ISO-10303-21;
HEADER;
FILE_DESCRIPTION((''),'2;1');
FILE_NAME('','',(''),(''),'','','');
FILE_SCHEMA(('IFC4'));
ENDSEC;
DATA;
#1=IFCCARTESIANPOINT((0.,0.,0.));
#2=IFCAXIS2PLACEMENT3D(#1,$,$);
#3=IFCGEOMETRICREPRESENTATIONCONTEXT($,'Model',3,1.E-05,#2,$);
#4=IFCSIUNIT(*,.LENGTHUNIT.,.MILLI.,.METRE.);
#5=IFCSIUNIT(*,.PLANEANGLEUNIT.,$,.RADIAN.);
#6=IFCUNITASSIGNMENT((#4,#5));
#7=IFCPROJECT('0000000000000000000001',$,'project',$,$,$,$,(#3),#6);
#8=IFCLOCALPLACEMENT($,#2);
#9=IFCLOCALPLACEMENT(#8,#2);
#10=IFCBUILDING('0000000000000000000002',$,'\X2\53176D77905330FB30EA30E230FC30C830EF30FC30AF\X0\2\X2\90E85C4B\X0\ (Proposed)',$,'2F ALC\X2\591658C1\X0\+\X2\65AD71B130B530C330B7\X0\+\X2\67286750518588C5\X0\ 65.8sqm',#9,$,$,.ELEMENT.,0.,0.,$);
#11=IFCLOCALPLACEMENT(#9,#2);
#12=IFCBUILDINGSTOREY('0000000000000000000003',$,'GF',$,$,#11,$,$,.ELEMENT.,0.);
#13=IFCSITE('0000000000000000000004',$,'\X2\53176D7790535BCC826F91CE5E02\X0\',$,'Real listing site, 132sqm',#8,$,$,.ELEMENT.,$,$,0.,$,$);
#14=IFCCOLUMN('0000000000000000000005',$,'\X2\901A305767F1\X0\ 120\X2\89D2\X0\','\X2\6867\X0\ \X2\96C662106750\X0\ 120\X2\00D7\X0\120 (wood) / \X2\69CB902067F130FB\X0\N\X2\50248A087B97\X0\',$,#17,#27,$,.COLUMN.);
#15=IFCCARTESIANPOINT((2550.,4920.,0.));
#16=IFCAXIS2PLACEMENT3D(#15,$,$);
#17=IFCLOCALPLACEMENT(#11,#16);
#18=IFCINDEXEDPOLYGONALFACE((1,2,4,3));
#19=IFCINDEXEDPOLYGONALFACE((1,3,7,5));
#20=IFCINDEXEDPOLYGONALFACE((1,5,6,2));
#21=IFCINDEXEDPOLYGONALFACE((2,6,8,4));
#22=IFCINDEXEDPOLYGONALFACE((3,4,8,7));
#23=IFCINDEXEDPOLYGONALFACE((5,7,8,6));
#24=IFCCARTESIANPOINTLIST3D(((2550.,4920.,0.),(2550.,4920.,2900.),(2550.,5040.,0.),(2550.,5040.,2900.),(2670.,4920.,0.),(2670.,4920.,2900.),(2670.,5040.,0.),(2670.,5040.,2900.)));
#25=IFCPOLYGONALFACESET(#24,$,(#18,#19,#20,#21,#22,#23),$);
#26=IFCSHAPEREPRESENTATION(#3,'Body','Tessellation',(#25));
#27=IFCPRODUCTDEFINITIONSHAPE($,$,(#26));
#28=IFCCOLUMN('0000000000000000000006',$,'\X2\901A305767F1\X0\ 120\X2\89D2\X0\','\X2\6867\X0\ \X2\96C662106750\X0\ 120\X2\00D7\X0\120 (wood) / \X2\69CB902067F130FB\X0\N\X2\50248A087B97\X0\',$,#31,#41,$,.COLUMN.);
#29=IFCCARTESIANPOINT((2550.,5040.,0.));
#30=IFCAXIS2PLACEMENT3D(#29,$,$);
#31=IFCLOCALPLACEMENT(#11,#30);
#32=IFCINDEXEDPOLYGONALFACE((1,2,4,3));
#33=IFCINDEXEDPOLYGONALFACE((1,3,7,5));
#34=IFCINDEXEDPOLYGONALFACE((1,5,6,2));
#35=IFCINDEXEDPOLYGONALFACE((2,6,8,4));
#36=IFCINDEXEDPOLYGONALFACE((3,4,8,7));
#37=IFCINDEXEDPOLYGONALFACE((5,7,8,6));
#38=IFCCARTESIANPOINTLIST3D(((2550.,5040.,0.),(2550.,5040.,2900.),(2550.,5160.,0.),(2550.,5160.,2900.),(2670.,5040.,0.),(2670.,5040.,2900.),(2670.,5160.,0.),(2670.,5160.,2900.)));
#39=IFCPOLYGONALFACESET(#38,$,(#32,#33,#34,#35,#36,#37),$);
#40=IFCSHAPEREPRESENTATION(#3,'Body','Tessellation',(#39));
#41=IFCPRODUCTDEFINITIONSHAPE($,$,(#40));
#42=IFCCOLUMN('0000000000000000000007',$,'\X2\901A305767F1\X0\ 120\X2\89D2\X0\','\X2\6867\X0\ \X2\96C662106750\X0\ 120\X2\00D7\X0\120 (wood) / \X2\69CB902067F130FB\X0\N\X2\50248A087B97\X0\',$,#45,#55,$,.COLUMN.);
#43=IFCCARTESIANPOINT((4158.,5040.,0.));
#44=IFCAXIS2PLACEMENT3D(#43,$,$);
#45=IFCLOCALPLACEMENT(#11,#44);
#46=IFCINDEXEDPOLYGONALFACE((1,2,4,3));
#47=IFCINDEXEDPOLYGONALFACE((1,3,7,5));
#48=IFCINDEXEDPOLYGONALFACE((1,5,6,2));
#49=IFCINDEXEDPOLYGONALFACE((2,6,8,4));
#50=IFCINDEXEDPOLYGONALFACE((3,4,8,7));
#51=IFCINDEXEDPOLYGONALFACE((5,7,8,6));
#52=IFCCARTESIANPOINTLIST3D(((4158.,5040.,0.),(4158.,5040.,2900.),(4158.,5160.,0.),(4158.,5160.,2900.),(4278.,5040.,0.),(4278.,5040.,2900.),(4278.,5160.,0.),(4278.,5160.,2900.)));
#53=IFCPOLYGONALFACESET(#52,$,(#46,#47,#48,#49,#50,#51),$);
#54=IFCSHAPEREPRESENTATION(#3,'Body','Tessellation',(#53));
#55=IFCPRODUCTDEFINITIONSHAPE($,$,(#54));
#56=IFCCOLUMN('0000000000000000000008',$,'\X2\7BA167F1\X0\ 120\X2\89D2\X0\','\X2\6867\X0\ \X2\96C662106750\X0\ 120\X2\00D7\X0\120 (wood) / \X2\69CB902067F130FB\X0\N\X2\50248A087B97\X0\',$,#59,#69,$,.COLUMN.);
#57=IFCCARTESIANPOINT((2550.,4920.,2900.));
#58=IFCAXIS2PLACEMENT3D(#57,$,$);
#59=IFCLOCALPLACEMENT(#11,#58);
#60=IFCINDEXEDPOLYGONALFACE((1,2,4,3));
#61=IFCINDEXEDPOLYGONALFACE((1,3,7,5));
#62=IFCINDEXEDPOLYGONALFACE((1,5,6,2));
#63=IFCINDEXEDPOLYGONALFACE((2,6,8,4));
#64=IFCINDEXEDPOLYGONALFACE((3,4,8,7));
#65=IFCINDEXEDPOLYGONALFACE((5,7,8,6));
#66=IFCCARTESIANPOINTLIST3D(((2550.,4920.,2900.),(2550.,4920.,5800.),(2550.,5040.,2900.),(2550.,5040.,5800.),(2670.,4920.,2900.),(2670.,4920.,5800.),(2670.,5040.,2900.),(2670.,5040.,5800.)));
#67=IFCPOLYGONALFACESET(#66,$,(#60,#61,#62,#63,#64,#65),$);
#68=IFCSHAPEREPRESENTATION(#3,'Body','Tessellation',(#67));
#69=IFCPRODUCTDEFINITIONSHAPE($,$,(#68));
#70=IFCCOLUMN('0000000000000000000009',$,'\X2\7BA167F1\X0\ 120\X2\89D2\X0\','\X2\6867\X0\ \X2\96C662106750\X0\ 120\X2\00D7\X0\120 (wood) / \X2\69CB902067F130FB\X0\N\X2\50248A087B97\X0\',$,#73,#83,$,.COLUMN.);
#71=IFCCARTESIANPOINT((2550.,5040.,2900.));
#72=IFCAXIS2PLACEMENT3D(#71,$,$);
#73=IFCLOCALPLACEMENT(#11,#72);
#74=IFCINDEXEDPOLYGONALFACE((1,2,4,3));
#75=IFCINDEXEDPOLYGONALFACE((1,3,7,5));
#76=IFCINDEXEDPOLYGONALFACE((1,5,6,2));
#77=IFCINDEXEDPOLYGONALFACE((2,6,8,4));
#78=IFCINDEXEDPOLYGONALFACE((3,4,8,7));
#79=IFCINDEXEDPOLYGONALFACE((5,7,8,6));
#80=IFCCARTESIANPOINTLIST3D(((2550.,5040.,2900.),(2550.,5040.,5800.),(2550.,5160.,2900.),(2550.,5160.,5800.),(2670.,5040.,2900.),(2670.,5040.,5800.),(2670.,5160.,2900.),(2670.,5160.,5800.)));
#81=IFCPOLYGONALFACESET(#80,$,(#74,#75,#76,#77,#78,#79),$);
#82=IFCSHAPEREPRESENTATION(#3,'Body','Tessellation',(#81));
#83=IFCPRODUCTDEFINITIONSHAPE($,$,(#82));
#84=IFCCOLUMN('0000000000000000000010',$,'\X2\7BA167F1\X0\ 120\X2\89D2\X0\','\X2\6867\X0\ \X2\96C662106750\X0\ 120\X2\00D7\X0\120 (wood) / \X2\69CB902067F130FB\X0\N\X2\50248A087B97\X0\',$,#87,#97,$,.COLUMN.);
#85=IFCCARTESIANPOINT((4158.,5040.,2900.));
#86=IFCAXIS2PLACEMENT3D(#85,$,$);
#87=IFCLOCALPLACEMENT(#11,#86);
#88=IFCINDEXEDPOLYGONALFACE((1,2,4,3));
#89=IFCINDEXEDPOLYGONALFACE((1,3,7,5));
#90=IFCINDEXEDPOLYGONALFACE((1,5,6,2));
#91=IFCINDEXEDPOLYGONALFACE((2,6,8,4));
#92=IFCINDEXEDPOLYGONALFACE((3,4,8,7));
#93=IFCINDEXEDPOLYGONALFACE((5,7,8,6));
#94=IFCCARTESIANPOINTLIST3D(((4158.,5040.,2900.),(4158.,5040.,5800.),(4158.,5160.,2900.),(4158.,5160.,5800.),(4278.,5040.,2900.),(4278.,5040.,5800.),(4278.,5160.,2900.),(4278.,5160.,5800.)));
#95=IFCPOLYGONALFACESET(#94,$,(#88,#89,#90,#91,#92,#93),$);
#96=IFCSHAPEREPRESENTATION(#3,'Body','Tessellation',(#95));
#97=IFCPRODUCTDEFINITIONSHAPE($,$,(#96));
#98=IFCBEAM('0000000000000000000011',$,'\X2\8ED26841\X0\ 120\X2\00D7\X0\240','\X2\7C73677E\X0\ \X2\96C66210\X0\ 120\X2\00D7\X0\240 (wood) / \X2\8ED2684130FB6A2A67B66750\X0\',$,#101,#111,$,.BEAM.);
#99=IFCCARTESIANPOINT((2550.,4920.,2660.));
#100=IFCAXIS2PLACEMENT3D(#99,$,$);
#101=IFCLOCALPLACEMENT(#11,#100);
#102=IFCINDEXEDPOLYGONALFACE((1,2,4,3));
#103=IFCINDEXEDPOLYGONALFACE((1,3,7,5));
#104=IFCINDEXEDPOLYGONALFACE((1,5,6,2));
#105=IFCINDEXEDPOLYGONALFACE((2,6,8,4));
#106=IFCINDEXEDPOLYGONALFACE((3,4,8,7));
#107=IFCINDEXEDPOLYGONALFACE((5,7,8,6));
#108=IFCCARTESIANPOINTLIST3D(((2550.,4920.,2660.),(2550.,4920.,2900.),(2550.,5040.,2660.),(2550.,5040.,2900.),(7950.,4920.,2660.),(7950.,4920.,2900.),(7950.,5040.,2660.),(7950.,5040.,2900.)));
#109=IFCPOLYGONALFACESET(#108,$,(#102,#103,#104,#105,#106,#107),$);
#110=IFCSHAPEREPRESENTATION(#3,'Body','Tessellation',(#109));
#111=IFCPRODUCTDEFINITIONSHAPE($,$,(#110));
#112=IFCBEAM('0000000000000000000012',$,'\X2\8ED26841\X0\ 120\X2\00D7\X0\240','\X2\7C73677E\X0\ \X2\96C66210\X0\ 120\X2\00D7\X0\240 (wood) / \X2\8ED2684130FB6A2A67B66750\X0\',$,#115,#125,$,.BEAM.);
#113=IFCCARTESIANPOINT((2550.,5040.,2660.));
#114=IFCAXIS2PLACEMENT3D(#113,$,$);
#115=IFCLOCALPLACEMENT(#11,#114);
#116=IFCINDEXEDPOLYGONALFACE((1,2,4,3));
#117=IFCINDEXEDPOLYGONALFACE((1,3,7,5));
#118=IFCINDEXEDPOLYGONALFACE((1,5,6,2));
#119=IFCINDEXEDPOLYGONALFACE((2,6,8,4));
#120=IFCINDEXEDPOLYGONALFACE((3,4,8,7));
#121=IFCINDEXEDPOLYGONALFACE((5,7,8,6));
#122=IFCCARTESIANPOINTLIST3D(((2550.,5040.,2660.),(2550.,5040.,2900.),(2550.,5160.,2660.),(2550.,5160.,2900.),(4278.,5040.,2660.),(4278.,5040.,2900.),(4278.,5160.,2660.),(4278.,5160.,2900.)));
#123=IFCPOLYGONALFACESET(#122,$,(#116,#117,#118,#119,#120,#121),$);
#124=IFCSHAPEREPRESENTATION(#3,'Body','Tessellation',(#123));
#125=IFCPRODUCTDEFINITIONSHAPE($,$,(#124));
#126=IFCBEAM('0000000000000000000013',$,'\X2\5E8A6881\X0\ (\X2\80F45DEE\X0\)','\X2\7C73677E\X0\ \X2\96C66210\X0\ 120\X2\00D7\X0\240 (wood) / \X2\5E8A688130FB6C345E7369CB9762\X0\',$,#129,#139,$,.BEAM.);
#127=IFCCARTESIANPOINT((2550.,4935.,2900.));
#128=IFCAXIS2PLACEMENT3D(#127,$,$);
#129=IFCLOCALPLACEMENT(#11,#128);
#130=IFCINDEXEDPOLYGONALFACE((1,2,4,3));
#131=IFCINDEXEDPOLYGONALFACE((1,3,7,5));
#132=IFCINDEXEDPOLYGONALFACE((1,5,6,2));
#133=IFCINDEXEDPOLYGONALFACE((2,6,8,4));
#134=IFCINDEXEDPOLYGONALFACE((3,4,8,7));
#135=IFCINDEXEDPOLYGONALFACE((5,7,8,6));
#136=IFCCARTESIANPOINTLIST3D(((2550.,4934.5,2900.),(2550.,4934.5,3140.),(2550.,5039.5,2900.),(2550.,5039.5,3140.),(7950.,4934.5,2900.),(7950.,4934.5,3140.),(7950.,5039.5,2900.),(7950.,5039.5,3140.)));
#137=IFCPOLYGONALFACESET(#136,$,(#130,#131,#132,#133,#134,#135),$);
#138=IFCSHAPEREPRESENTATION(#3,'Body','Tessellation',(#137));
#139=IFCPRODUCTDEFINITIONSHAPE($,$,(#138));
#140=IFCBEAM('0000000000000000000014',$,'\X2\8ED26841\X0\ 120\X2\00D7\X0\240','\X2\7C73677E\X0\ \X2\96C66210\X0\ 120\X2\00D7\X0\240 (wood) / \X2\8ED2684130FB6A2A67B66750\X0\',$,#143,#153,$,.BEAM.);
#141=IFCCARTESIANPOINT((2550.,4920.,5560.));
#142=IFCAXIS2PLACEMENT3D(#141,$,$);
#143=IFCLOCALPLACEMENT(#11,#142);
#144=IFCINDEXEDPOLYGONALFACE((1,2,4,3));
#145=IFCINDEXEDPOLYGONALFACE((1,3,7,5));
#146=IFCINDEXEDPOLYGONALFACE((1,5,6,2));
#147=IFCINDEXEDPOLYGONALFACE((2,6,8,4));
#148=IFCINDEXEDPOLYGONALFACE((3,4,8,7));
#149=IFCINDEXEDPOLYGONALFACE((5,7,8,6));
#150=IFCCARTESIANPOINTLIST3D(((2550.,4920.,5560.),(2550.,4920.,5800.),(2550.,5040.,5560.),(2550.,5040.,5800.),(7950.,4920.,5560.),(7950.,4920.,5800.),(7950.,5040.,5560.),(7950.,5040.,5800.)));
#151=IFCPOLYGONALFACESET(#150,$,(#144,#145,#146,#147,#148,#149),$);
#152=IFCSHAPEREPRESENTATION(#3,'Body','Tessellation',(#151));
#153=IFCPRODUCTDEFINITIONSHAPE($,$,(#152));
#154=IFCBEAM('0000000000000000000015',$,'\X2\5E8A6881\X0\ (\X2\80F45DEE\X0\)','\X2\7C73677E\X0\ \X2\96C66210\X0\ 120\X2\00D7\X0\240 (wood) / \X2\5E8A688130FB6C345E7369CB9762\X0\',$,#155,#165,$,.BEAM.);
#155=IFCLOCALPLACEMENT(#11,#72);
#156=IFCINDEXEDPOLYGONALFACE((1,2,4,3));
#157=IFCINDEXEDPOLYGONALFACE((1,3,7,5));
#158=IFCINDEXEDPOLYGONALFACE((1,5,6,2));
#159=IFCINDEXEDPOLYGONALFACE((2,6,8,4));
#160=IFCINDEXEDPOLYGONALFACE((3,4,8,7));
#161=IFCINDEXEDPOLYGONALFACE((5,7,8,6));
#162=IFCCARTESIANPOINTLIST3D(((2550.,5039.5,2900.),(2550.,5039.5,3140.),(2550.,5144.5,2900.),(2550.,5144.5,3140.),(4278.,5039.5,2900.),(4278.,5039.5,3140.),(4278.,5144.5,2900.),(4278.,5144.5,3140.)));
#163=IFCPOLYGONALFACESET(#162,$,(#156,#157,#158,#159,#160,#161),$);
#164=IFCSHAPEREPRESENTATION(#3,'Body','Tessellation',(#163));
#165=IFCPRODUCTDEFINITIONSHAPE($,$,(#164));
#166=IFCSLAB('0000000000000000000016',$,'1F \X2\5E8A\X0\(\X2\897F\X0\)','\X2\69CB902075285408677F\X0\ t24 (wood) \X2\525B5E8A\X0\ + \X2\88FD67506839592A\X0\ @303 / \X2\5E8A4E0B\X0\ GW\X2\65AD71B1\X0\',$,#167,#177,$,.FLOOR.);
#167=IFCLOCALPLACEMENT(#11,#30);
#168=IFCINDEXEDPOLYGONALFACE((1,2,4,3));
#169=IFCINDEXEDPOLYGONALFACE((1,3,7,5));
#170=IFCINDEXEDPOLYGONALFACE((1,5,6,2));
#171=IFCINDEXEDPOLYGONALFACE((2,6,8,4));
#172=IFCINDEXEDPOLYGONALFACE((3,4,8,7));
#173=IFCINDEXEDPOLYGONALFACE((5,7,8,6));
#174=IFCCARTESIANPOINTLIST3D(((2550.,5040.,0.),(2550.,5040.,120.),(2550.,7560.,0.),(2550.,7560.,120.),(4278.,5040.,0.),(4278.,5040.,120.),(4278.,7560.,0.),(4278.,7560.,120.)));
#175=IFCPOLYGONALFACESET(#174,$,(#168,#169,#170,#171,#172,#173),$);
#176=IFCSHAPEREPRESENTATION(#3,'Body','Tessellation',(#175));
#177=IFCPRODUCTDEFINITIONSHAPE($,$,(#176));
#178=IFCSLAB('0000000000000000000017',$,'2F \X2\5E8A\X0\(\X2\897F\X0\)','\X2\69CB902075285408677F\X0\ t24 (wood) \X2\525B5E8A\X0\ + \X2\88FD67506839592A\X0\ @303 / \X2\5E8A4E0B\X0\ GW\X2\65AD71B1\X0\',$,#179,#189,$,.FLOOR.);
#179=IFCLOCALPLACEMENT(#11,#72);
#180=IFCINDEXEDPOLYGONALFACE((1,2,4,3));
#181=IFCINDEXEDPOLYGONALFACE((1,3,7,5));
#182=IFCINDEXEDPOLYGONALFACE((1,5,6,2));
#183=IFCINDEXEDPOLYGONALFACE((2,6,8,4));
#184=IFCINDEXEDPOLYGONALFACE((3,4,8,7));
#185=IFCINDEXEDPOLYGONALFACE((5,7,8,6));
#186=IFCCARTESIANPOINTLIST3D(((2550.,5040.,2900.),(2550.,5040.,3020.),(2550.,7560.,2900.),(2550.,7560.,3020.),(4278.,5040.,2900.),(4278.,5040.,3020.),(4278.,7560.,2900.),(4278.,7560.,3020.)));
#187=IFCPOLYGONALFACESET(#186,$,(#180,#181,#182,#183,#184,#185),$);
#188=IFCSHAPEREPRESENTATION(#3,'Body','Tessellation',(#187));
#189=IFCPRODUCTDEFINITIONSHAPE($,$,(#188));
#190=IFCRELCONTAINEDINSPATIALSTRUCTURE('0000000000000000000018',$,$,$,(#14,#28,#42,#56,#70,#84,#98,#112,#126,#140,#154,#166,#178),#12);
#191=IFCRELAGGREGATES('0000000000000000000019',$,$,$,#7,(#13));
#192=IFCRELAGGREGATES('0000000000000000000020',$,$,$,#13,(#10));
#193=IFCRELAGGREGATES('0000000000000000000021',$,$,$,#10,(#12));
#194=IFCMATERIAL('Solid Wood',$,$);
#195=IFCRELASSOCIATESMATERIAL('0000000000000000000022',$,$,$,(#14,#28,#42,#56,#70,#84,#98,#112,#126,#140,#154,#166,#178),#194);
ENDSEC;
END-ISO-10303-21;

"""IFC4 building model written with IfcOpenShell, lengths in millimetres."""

from ifc_helpers import new_model, si_unit, frame, frame_2d, origin, place, context, project, spatial, rectangle, extrude, material, element, save


model = new_model("IFC4")

# Units and contexts
model_context = context("Model", 3, precision=1e-05, world=origin())
ifc_project = project(units=[si_unit("LENGTHUNIT", "METRE", prefix="MILLI"), si_unit("PLANEANGLEUNIT", "RADIAN")], contexts=[model_context])

# Site, building, storey
site_placement = place(None, origin())
site = spatial("IfcSite", under=ifc_project, at=site_placement, Name="北海道富良野市", ObjectType="Real listing site, 132sqm", CompositionType="ELEMENT", RefElevation=0.0)
building_placement = place(site_placement, origin())
building = spatial("IfcBuilding", under=site, at=building_placement, Name="北海道・リモートワーク2部屋 (Proposed)", ObjectType="2F ALC外壁+断熱サッシ+木材内装 65.8sqm", CompositionType="ELEMENT", ElevationOfRefHeight=0.0, ElevationOfTerrain=0.0)
storey_placement = place(building_placement, origin())
storey = spatial("IfcBuildingStorey", under=building, at=storey_placement, Name="GF", CompositionType="ELEMENT", Elevation=0.0)

# Columns
ifc_material_1 = material(Name="Solid Wood")
column_1_placement = place(storey_placement, frame((2550.0, 4920.0, 0.0)))
element("IfcColumn", 1, at=column_1_placement, inside=storey, material=ifc_material_1, Name="通し柱 120角", Description="桧 集成材 120×120 (wood) / 構造柱・N値計算", PredefinedType="COLUMN", context=model_context, shape_type="SweptSolid", body=[
    extrude(rectangle(XDim=120.0, YDim=120.0, at=frame_2d((60.0, 60.0))), frame((2550.0, 4920.0, 0.0)), (0.0, 0.0, 1.0), 2900.0),
])
column_2_placement = place(storey_placement, frame((2550.0, 5040.0, 0.0)))
element("IfcColumn", 2, at=column_2_placement, inside=storey, material=ifc_material_1, Name="通し柱 120角", Description="桧 集成材 120×120 (wood) / 構造柱・N値計算", PredefinedType="COLUMN", context=model_context, shape_type="SweptSolid", body=[
    extrude(rectangle(XDim=120.0, YDim=120.0, at=frame_2d((60.0, 60.0))), frame((2550.0, 5040.0, 0.0)), (0.0, 0.0, 1.0), 2900.0),
])
column_3_placement = place(storey_placement, frame((4158.0, 5040.0, 0.0)))
element("IfcColumn", 3, at=column_3_placement, inside=storey, material=ifc_material_1, Name="通し柱 120角", Description="桧 集成材 120×120 (wood) / 構造柱・N値計算", PredefinedType="COLUMN", context=model_context, shape_type="SweptSolid", body=[
    extrude(rectangle(XDim=120.0, YDim=120.0, at=frame_2d((60.0, 60.0))), frame((4158.0, 5040.0, 0.0)), (0.0, 0.0, 1.0), 2900.0),
])
column_4_placement = place(storey_placement, frame((2550.0, 4920.0, 2900.0)))
element("IfcColumn", 4, at=column_4_placement, inside=storey, material=ifc_material_1, Name="管柱 120角", Description="桧 集成材 120×120 (wood) / 構造柱・N値計算", PredefinedType="COLUMN", context=model_context, shape_type="SweptSolid", body=[
    extrude(rectangle(XDim=120.0, YDim=120.0, at=frame_2d((60.0, 60.0))), frame((2550.0, 4920.0, 2900.0)), (0.0, 0.0, 1.0), 2900.0),
])
column_5_placement = place(storey_placement, frame((2550.0, 5040.0, 2900.0)))
element("IfcColumn", 5, at=column_5_placement, inside=storey, material=ifc_material_1, Name="管柱 120角", Description="桧 集成材 120×120 (wood) / 構造柱・N値計算", PredefinedType="COLUMN", context=model_context, shape_type="SweptSolid", body=[
    extrude(rectangle(XDim=120.0, YDim=120.0, at=frame_2d((60.0, 60.0))), frame((2550.0, 5040.0, 2900.0)), (0.0, 0.0, 1.0), 2900.0),
])
column_6_placement = place(storey_placement, frame((4158.0, 5040.0, 2900.0)))
element("IfcColumn", 6, at=column_6_placement, inside=storey, material=ifc_material_1, Name="管柱 120角", Description="桧 集成材 120×120 (wood) / 構造柱・N値計算", PredefinedType="COLUMN", context=model_context, shape_type="SweptSolid", body=[
    extrude(rectangle(XDim=120.0, YDim=120.0, at=frame_2d((60.0, 60.0))), frame((4158.0, 5040.0, 2900.0)), (0.0, 0.0, 1.0), 2900.0),
])

# Beams
beam_1_placement = place(storey_placement, frame((2550.0, 4920.0, 2660.0)))
element("IfcBeam", 7, at=beam_1_placement, inside=storey, material=ifc_material_1, Name="軒桁 120×240", Description="米松 集成 120×240 (wood) / 軒桁・横架材", PredefinedType="BEAM", context=model_context, shape_type="SweptSolid", body=[
    extrude(rectangle(XDim=5400.0, YDim=120.0, at=frame_2d((2700.0, 60.0))), frame((2550.0, 4920.0, 2660.0)), (0.0, 0.0, 1.0), 240.0),
])
beam_2_placement = place(storey_placement, frame((2550.0, 5040.0, 2660.0)))
element("IfcBeam", 8, at=beam_2_placement, inside=storey, material=ifc_material_1, Name="軒桁 120×240", Description="米松 集成 120×240 (wood) / 軒桁・横架材", PredefinedType="BEAM", context=model_context, shape_type="SweptSolid", body=[
    extrude(rectangle(XDim=1728.0, YDim=120.0, at=frame_2d((864.0, 60.0))), frame((2550.0, 5040.0, 2660.0)), (0.0, 0.0, 1.0), 240.0),
])
beam_3_placement = place(storey_placement, frame((2550.0, 4935.0, 2900.0)))
element("IfcBeam", 9, at=beam_3_placement, inside=storey, material=ifc_material_1, Name="床梁 (胴差)", Description="米松 集成 120×240 (wood) / 床梁・水平構面", PredefinedType="BEAM", context=model_context, shape_type="SweptSolid", body=[
    extrude(rectangle(XDim=5400.0, YDim=105.0, at=frame_2d((2700.0, 52.0))), frame((2550.0, 4935.0, 2900.0)), (0.0, 0.0, 1.0), 240.0),
])
beam_4_placement = place(storey_placement, frame((2550.0, 4920.0, 5560.0)))
element("IfcBeam", 10, at=beam_4_placement, inside=storey, material=ifc_material_1, Name="軒桁 120×240", Description="米松 集成 120×240 (wood) / 軒桁・横架材", PredefinedType="BEAM", context=model_context, shape_type="SweptSolid", body=[
    extrude(rectangle(XDim=5400.0, YDim=120.0, at=frame_2d((2700.0, 60.0))), frame((2550.0, 4920.0, 5560.0)), (0.0, 0.0, 1.0), 240.0),
])
beam_5_placement = place(storey_placement, frame((2550.0, 5040.0, 2900.0)))
element("IfcBeam", 11, at=beam_5_placement, inside=storey, material=ifc_material_1, Name="床梁 (胴差)", Description="米松 集成 120×240 (wood) / 床梁・水平構面", PredefinedType="BEAM", context=model_context, shape_type="SweptSolid", body=[
    extrude(rectangle(XDim=1728.0, YDim=105.0, at=frame_2d((864.0, 52.0))), frame((2550.0, 5040.0, 2900.0)), (0.0, 0.0, 1.0), 240.0),
])

# Slabs
slab_1_placement = place(storey_placement, frame((2550.0, 5040.0, 0.0)))
element("IfcSlab", 12, at=slab_1_placement, inside=storey, material=ifc_material_1, Name="1F 床(西)", Description="構造用合板 t24 (wood) 剛床 + 製材根太 @303 / 床下 GW断熱", PredefinedType="FLOOR", context=model_context, shape_type="SweptSolid", body=[
    extrude(rectangle(XDim=1728.0, YDim=2520.0, at=frame_2d((864.0, 1260.0))), frame((2550.0, 5040.0, 0.0)), (0.0, 0.0, 1.0), 120.0),
])
slab_2_placement = place(storey_placement, frame((2550.0, 5040.0, 2900.0)))
element("IfcSlab", 13, at=slab_2_placement, inside=storey, material=ifc_material_1, Name="2F 床(西)", Description="構造用合板 t24 (wood) 剛床 + 製材根太 @303 / 床下 GW断熱", PredefinedType="FLOOR", context=model_context, shape_type="SweptSolid", body=[
    extrude(rectangle(XDim=1728.0, YDim=2520.0, at=frame_2d((864.0, 1260.0))), frame((2550.0, 5040.0, 2900.0)), (0.0, 0.0, 1.0), 120.0),
])

save(model, "model.ifc")
